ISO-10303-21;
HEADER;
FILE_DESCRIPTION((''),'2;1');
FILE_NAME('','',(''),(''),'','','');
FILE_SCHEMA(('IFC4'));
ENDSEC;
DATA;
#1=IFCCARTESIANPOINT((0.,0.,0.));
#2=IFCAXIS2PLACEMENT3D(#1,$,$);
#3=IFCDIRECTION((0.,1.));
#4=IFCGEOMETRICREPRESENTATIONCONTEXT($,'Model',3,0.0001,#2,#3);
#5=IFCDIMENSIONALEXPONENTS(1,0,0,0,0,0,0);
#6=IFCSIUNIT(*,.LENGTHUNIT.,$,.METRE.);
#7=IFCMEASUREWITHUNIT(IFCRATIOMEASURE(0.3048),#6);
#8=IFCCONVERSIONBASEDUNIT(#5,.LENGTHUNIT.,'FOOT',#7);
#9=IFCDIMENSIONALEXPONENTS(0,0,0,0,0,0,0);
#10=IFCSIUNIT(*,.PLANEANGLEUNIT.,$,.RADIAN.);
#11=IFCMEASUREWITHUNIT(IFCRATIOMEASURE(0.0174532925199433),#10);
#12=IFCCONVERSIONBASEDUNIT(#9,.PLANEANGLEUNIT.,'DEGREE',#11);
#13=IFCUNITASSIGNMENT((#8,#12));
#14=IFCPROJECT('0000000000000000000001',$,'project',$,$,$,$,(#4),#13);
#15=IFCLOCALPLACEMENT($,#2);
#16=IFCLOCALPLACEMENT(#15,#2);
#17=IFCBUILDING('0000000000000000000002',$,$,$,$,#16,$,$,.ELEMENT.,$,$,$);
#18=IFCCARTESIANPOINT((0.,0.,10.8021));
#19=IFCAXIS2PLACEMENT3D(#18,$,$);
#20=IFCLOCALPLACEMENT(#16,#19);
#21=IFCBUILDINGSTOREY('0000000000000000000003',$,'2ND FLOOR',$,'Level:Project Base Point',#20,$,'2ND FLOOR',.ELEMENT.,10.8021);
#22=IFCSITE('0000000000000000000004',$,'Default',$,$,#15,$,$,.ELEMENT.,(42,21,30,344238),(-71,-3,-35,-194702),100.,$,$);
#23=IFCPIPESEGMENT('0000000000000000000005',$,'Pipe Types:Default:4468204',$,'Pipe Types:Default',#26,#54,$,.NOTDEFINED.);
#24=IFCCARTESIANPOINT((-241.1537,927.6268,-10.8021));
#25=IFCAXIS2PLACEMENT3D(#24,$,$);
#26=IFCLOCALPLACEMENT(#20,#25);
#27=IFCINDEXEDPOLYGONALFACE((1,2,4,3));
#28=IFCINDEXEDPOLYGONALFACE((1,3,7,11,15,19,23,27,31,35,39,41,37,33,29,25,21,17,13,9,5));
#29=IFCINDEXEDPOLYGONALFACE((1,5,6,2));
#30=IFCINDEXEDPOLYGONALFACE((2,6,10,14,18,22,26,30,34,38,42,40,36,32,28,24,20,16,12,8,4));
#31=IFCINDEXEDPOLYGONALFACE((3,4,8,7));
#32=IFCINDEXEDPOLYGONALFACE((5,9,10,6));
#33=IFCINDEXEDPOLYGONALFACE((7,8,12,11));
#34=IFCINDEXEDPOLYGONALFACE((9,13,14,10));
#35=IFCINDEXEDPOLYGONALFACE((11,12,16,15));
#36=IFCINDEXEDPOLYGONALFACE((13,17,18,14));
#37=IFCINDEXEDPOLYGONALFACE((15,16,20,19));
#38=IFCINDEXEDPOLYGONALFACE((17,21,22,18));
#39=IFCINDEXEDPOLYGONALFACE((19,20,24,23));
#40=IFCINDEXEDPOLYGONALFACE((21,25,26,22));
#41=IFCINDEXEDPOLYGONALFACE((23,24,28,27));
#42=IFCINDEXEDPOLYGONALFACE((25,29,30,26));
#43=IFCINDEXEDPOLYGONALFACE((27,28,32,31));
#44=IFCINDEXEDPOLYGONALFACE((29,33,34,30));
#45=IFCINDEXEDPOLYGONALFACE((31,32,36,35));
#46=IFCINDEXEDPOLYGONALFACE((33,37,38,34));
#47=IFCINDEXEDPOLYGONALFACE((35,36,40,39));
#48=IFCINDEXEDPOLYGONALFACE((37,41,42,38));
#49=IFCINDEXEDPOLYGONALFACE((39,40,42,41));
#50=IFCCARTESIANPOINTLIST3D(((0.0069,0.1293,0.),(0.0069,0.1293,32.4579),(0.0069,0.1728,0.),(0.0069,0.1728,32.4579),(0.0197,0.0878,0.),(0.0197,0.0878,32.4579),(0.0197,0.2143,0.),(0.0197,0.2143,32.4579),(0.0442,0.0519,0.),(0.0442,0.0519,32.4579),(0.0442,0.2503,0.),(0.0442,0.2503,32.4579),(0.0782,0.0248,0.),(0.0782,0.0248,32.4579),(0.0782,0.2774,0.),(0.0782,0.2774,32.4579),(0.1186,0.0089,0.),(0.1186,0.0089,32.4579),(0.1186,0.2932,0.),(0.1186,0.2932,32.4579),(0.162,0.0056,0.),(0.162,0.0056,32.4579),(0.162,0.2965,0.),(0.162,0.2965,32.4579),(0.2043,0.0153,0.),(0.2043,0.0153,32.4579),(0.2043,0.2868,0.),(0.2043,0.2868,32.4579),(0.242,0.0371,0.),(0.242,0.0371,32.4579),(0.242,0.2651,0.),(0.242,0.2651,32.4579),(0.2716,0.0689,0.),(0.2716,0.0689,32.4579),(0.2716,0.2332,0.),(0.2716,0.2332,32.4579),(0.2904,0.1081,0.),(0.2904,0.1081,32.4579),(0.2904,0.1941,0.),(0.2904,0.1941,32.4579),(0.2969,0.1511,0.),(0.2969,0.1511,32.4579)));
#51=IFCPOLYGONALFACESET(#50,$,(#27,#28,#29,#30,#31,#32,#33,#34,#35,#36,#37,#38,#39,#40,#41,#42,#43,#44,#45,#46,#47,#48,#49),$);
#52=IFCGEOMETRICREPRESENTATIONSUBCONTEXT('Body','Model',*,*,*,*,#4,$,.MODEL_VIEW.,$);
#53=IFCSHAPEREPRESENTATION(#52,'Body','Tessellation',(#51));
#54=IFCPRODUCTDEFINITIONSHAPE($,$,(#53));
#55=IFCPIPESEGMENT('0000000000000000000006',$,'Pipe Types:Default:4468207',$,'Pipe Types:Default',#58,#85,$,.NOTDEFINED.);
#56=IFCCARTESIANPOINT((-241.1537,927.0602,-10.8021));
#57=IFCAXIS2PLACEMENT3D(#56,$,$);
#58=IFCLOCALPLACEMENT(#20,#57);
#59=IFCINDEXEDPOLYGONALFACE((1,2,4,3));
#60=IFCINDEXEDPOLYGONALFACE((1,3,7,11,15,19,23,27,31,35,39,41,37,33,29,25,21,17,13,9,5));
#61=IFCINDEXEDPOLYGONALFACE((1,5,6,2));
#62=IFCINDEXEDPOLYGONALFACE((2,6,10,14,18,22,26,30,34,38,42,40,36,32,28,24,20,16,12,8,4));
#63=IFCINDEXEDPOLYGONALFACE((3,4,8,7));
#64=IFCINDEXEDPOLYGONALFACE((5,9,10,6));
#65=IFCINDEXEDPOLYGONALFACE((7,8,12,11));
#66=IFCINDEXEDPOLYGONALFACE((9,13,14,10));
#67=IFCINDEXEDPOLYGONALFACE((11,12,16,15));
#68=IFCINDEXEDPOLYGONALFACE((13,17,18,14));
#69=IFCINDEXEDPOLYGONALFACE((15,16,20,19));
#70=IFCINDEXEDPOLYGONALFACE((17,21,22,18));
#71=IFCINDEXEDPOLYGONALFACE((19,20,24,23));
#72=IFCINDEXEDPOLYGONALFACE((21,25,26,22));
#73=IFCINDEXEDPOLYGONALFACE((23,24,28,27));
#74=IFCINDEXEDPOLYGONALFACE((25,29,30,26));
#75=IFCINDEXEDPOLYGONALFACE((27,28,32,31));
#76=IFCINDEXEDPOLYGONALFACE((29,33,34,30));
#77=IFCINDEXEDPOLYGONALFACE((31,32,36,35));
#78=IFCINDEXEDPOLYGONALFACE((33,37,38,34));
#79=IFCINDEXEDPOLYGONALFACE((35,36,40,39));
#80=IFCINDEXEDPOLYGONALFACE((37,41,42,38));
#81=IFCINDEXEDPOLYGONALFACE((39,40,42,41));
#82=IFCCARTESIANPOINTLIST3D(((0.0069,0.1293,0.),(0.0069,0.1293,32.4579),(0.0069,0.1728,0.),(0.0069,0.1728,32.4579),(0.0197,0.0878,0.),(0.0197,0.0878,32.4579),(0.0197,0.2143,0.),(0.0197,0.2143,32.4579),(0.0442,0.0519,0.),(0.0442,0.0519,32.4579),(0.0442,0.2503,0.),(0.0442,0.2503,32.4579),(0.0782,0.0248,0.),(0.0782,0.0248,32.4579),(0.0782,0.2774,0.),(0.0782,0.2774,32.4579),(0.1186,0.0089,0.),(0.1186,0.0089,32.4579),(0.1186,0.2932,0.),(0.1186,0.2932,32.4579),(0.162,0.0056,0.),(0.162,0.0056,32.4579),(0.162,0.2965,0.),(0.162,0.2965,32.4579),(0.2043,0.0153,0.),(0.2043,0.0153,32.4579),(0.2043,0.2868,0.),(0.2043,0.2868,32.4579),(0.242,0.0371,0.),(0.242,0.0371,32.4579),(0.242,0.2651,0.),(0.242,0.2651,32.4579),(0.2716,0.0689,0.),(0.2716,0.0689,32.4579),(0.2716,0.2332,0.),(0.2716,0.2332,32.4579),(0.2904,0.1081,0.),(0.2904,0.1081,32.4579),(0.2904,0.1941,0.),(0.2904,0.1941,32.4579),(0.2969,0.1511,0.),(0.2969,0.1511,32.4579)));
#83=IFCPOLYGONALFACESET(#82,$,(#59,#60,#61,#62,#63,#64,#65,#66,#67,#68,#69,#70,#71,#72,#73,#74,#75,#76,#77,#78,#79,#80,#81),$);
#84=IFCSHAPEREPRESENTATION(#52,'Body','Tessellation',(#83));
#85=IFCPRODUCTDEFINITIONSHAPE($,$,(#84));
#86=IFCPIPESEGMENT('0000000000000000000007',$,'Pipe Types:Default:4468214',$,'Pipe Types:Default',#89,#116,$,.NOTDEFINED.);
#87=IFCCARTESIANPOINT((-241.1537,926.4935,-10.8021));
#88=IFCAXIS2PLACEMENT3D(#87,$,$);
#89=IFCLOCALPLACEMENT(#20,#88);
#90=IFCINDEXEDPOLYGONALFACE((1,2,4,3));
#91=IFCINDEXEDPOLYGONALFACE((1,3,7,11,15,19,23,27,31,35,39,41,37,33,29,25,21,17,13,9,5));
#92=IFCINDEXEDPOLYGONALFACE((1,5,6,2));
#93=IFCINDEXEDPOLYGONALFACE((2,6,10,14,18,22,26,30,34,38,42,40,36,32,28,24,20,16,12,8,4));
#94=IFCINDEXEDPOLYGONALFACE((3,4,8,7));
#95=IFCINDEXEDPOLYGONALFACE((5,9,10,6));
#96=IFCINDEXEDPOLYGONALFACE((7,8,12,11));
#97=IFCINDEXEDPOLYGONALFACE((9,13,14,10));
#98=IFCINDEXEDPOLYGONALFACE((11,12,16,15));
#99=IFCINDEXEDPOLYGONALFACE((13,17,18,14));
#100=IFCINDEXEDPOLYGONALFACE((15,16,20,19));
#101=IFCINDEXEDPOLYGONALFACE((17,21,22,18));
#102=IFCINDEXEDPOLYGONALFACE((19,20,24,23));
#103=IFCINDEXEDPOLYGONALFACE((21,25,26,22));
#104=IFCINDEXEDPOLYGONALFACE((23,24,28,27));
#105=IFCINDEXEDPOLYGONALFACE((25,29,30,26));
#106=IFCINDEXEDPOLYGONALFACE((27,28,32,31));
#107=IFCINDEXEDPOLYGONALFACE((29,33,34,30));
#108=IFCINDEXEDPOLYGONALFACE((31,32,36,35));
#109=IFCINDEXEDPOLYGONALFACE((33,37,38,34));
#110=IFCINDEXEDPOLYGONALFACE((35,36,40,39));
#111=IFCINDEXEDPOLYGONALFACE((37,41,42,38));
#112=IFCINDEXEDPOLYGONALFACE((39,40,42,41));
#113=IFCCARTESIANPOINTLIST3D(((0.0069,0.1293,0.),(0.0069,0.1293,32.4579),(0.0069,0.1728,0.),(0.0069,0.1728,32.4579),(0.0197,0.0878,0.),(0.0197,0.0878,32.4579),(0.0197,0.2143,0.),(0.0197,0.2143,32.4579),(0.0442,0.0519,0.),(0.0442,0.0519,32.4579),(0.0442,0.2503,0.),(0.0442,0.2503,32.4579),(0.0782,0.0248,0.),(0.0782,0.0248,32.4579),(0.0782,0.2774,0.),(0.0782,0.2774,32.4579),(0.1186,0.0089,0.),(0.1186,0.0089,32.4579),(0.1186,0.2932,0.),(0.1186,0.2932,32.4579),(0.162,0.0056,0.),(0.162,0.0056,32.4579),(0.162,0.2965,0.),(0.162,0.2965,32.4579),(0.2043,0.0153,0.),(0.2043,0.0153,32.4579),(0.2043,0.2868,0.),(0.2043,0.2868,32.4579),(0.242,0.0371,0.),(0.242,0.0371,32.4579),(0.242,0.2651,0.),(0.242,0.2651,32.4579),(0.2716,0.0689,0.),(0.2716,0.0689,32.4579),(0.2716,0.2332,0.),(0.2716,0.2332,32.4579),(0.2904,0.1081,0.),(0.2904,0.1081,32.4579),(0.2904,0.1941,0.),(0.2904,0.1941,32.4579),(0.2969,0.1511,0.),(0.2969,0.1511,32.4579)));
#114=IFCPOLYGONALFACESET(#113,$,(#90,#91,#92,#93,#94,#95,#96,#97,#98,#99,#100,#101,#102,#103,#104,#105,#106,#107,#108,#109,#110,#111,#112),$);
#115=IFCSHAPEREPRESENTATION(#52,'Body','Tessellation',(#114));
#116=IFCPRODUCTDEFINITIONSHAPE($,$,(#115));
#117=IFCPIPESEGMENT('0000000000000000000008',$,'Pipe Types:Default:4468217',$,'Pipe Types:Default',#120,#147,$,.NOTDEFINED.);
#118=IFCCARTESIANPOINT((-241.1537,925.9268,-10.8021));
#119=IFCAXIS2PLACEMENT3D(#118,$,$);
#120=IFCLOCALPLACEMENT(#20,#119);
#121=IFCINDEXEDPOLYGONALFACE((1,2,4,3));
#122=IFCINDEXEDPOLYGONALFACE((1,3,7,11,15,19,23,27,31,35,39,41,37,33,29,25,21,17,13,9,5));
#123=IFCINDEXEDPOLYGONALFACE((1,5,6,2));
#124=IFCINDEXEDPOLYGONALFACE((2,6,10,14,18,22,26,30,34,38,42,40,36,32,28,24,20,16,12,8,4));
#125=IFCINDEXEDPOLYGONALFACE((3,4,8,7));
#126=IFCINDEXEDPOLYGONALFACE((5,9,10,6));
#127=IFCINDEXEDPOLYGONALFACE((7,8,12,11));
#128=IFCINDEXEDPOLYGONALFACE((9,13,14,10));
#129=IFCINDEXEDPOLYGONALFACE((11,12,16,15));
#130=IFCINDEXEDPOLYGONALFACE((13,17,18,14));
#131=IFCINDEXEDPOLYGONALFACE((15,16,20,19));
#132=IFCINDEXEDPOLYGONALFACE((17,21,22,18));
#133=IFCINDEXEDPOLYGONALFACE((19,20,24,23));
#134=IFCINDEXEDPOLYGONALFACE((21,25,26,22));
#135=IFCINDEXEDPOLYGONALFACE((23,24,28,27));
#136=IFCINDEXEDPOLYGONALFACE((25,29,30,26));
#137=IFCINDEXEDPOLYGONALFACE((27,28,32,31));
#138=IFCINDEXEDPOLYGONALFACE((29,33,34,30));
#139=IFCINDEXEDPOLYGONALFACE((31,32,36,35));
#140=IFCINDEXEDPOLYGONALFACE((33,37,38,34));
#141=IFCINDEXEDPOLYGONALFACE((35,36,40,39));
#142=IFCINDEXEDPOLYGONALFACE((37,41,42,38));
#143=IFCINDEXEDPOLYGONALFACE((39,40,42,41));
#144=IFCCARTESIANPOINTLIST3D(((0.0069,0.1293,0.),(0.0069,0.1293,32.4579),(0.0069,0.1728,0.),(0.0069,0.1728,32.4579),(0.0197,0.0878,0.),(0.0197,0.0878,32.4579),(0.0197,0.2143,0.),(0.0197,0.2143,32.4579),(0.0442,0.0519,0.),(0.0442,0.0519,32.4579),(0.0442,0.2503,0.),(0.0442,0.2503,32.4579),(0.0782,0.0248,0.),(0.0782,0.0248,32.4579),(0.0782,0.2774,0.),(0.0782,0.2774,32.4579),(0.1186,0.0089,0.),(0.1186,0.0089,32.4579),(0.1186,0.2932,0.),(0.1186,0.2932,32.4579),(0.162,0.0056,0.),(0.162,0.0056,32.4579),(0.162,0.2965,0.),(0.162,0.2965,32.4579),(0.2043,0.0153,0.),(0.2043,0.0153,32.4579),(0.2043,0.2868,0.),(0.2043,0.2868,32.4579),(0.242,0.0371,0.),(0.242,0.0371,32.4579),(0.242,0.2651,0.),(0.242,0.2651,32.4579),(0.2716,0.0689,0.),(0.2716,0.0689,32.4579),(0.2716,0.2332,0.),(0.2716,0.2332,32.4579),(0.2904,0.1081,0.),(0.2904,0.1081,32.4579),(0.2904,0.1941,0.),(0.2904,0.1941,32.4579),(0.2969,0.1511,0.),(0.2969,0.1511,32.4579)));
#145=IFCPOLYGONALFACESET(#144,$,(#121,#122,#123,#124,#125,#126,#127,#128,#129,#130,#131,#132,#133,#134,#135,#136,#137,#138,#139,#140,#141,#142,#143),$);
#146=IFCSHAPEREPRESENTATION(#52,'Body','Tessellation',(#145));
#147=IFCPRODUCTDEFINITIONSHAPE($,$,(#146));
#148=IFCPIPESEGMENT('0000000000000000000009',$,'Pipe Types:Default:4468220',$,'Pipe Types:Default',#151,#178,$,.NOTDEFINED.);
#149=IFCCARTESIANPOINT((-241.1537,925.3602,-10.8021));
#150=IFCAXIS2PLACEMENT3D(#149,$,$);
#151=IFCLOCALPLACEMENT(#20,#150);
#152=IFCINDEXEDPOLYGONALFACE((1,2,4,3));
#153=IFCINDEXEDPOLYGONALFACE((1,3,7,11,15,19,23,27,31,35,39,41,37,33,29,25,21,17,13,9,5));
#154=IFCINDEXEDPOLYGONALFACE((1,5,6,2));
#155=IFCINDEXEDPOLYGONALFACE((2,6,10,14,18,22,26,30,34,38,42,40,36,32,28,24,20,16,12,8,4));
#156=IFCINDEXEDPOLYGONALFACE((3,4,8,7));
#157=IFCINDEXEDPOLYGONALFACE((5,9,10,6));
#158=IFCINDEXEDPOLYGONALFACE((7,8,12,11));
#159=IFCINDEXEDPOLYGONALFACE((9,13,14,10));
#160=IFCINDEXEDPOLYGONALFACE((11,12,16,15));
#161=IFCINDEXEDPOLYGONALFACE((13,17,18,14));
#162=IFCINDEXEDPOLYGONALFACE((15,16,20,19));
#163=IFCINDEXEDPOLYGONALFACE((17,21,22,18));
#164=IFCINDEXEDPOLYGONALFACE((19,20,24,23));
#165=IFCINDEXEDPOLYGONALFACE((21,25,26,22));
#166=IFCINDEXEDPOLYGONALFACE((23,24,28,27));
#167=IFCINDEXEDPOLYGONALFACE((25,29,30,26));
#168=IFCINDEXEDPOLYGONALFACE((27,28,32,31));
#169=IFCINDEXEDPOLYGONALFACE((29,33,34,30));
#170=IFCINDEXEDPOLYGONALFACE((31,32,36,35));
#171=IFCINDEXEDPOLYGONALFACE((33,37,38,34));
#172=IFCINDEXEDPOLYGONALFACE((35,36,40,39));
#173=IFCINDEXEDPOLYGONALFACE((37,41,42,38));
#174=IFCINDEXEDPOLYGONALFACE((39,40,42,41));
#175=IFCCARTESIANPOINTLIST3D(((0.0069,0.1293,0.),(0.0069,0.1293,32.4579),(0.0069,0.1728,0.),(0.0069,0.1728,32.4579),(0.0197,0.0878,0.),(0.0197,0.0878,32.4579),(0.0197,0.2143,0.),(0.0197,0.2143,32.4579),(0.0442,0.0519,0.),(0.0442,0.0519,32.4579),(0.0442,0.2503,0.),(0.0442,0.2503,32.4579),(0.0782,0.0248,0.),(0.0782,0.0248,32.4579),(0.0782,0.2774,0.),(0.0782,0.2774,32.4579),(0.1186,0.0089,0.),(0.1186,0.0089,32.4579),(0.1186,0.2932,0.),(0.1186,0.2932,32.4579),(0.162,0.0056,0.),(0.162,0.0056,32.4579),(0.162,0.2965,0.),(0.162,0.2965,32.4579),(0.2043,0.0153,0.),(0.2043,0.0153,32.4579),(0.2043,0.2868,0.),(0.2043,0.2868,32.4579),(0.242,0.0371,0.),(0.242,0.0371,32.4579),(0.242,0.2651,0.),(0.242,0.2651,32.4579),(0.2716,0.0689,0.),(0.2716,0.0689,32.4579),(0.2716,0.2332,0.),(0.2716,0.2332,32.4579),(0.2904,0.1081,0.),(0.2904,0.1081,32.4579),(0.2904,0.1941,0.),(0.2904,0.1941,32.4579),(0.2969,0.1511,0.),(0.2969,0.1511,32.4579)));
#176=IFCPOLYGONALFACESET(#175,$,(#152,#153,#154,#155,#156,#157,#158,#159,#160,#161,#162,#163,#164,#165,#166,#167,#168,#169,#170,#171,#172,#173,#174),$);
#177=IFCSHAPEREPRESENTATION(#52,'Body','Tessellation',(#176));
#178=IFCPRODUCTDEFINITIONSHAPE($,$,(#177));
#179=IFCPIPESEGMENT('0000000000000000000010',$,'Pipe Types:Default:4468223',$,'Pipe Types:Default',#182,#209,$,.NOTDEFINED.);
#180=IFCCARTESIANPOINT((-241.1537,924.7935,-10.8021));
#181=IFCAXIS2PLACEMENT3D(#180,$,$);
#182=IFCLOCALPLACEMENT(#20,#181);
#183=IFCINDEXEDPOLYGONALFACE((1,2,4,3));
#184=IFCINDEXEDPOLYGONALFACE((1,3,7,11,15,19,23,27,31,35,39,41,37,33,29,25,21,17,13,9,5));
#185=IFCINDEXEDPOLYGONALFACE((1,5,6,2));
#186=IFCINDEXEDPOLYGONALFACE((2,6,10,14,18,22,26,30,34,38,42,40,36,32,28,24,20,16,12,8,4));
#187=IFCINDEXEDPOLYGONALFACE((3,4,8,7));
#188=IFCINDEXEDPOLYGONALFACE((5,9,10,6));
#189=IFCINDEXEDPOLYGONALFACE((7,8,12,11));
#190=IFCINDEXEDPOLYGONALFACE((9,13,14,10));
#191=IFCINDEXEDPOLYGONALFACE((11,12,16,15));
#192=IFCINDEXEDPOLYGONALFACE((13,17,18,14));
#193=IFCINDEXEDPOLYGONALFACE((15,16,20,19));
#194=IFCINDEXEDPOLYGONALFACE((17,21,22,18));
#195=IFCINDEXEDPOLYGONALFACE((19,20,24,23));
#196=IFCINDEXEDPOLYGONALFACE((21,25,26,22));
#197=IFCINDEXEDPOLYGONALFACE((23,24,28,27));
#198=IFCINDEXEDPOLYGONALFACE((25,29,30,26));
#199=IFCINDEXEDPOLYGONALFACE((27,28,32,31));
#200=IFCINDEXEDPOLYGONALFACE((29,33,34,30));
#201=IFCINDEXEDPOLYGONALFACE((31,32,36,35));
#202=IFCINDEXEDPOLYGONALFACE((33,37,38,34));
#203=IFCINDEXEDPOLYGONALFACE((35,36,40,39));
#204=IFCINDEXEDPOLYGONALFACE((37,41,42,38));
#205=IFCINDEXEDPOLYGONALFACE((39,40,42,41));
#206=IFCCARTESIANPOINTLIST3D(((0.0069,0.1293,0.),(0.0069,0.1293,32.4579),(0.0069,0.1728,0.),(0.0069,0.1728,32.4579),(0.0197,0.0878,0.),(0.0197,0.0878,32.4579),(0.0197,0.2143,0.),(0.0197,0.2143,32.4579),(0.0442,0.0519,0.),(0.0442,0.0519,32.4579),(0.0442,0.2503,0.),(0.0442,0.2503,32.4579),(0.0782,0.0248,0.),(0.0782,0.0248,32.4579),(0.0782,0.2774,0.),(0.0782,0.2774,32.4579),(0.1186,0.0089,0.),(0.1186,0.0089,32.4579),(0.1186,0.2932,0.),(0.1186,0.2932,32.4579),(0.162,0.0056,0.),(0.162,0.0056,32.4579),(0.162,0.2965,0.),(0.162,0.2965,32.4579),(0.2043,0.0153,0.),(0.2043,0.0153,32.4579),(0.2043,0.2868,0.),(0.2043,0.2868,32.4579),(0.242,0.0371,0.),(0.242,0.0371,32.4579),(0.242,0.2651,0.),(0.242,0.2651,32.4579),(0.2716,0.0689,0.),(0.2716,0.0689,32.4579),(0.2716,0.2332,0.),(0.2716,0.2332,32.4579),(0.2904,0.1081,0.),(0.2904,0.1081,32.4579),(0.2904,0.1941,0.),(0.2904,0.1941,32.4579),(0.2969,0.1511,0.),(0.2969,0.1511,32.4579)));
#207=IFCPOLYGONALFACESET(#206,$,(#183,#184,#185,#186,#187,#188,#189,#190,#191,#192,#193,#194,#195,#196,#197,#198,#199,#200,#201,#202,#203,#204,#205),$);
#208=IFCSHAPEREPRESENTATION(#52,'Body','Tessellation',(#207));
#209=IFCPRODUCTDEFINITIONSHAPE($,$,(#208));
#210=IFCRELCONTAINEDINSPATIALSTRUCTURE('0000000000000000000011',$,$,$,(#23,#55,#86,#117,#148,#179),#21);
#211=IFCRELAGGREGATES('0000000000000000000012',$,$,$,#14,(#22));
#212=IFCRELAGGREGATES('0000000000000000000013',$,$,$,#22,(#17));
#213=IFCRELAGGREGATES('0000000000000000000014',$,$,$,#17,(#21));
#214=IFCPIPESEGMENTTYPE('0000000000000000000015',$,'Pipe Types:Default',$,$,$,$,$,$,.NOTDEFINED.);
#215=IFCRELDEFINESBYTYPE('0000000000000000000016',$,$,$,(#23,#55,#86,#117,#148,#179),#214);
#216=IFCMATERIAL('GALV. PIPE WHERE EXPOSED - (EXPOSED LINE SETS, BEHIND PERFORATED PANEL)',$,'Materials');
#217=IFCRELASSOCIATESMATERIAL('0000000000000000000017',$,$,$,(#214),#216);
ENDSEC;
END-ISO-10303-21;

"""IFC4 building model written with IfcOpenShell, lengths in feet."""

from ifc_helpers import new_model, entity, si_unit, converted_unit, direction, frame, frame_2d, origin, origin_2d_with_axis, place, context, subcontext, project, spatial, circle, extrude, material, type_object, element, save


model = new_model("IFC4")

# Units and contexts
model_context = context("Model", 3, precision=0.0001, world=origin(), true_north=direction((0.0, 1.0)))
body_context = subcontext(model_context, "Body", "Model", "MODEL_VIEW")
ifc_project = project(units=[converted_unit("LENGTHUNIT", "FOOT", entity("IfcRatioMeasure", 0.3048), si_unit("LENGTHUNIT", "METRE"), dimensions=[1, 0, 0, 0, 0, 0, 0]), converted_unit("PLANEANGLEUNIT", "DEGREE", entity("IfcRatioMeasure", 0.0174532925199433), si_unit("PLANEANGLEUNIT", "RADIAN"), dimensions=[0, 0, 0, 0, 0, 0, 0])], contexts=[model_context])

# Site, building, storey
site_placement = place(None, origin())
site = spatial("IfcSite", under=ifc_project, at=site_placement, Name="Default", CompositionType="ELEMENT", RefLatitude=(42, 21, 30, 344238), RefLongitude=(-71, -3, -35, -194702), RefElevation=100.0)
building_placement = place(site_placement, origin())
building = spatial("IfcBuilding", under=site, at=building_placement, CompositionType="ELEMENT")
storey_placement = place(building_placement, frame((0.0, 0.0, 10.8021)))
storey = spatial("IfcBuildingStorey", under=building, at=storey_placement, Name="2ND FLOOR", ObjectType="Level:Project Base Point", LongName="2ND FLOOR", CompositionType="ELEMENT", Elevation=10.8021)

# Pipe segments
ifc_material_1 = material(Name="GALV. PIPE WHERE EXPOSED - (EXPOSED LINE SETS, BEHIND PERFORATED PANEL)", Category="Materials")
pipe_segment_type = type_object("IfcPipeSegmentType", Name="Pipe Types:Default", PredefinedType="NOTDEFINED", material=ifc_material_1)
pipe_segment_1_placement = place(storey_placement, frame((-241.1537, 927.6268, -10.8021)))
element("IfcPipeSegment", 1, at=pipe_segment_1_placement, inside=storey, type_object=pipe_segment_type, Name="Pipe Types:Default:4468204", ObjectType="Pipe Types:Default", PredefinedType="NOTDEFINED", context=body_context, shape_type="SweptSolid", body=[
    extrude(circle(Radius=0.1458, at=frame_2d((0.0, 0.0), x_axis=(1.0, 0.0))), frame((0.1511, 0.1511, 0.0)), (0.0, 0.0, 1.0), 32.4579),
])
for number, where, name in (
    (2, (-241.1537, 927.0602, -10.8021), "Pipe Types:Default:4468207"),
    (3, (-241.1537, 926.4935, -10.8021), "Pipe Types:Default:4468214"),
):
    element("IfcPipeSegment", number, at=place(storey_placement, frame(where)), inside=storey, type_object=pipe_segment_type, Name=name, ObjectType="Pipe Types:Default", PredefinedType="NOTDEFINED", context=body_context, shape_type="SweptSolid", body=[
        extrude(circle(Radius=0.1458, at=origin_2d_with_axis()), frame((0.1511, 0.1511, 0.0)), (0.0, 0.0, 1.0), 32.4579),
    ])
pipe_segment_2_placement = place(storey_placement, frame((-241.1537, 925.9268, -10.8021)))
element("IfcPipeSegment", 4, at=pipe_segment_2_placement, inside=storey, type_object=pipe_segment_type, Name="Pipe Types:Default:4468217", ObjectType="Pipe Types:Default", PredefinedType="NOTDEFINED", context=body_context, shape_type="SweptSolid", body=[
    extrude(circle(Radius=0.1458, at=frame_2d((0.0, 0.0), x_axis=(1.0, 0.0))), frame((0.1511, 0.1511, 0.0)), (0.0, 0.0, 1.0), 32.4579),
])
for number, where, name in (
    (5, (-241.1537, 925.3602, -10.8021), "Pipe Types:Default:4468220"),
    (6, (-241.1537, 924.7935, -10.8021), "Pipe Types:Default:4468223"),
):
    element("IfcPipeSegment", number, at=place(storey_placement, frame(where)), inside=storey, type_object=pipe_segment_type, Name=name, ObjectType="Pipe Types:Default", PredefinedType="NOTDEFINED", context=body_context, shape_type="SweptSolid", body=[
        extrude(circle(Radius=0.1458, at=origin_2d_with_axis()), frame((0.1511, 0.1511, 0.0)), (0.0, 0.0, 1.0), 32.4579),
    ])

save(model, "model.ifc")
